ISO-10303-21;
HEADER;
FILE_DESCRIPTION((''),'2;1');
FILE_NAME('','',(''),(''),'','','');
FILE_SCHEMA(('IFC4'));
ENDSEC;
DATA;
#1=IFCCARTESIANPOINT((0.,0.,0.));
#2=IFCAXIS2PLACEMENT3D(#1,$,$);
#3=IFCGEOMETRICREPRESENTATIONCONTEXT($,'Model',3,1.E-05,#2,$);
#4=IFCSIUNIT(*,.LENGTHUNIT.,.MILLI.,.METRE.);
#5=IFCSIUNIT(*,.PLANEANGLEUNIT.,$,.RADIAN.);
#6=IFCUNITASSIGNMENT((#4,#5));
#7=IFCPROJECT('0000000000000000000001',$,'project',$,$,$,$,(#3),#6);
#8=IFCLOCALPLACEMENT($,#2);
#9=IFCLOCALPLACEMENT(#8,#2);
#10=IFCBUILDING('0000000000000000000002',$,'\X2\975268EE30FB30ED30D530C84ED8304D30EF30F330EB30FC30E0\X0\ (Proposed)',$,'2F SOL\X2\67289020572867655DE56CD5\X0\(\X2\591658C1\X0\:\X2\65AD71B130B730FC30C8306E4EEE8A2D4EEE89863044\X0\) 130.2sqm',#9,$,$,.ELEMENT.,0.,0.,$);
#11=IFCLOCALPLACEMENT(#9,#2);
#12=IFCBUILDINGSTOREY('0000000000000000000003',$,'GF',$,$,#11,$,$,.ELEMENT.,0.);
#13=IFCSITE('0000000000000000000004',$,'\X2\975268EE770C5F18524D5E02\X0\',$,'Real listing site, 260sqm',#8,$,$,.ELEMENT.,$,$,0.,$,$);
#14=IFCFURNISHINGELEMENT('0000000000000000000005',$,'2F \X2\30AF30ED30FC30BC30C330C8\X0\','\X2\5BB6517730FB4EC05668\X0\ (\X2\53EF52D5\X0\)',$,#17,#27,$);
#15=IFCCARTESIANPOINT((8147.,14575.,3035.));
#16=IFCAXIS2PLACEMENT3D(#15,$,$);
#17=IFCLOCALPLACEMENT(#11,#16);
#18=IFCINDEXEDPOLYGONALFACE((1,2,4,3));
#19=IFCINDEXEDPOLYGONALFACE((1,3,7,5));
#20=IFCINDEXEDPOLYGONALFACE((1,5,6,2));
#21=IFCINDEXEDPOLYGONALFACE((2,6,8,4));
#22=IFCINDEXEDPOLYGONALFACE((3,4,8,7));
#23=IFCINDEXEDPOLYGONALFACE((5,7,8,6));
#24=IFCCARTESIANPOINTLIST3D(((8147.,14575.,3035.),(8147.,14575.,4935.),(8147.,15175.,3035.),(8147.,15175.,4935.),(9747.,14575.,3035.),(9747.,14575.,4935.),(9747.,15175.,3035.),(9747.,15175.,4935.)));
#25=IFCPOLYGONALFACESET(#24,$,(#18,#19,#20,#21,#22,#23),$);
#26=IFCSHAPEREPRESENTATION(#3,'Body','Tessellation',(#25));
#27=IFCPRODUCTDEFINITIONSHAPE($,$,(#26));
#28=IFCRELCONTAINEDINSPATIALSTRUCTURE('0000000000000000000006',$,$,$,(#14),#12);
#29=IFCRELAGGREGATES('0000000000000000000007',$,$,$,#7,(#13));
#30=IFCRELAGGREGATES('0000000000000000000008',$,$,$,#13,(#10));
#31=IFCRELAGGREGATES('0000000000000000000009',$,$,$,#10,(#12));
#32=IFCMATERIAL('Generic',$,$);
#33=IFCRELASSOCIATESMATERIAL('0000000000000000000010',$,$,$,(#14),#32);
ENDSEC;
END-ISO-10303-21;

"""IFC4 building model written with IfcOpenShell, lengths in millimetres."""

from ifc_helpers import new_model, si_unit, frame, frame_2d, origin, place, context, project, spatial, rectangle, extrude, material, element, save


model = new_model("IFC4")

# Units and contexts
model_context = context("Model", 3, precision=1e-05, world=origin())
ifc_project = project(units=[si_unit("LENGTHUNIT", "METRE", prefix="MILLI"), si_unit("PLANEANGLEUNIT", "RADIAN")], contexts=[model_context])

# Site, building, storey
site_placement = place(None, origin())
site = spatial("IfcSite", under=ifc_project, at=site_placement, Name="青森県弘前市", ObjectType="Real listing site, 260sqm", CompositionType="ELEMENT", RefElevation=0.0)
building_placement = place(site_placement, origin())
building = spatial("IfcBuilding", under=site, at=building_placement, Name="青森・ロフト付きワンルーム (Proposed)", ObjectType="2F SOL木造在来工法(外壁:断熱シートの仮設仮覆い) 130.2sqm", CompositionType="ELEMENT", ElevationOfRefHeight=0.0, ElevationOfTerrain=0.0)
storey_placement = place(building_placement, origin())
storey = spatial("IfcBuildingStorey", under=building, at=storey_placement, Name="GF", CompositionType="ELEMENT", Elevation=0.0)

# Shared definitions
ifc_material_1 = material(Name="Generic")

# Furnishing element
furnishing_1_placement = place(storey_placement, frame((8147.0, 14575.0, 3035.0)))
element("IfcFurnishingElement", 1, at=furnishing_1_placement, inside=storey, material=ifc_material_1, Name="2F クローゼット", Description="家具・什器 (可動)", context=model_context, shape_type="SweptSolid", body=[
    extrude(rectangle(XDim=1600.0, YDim=600.0, at=frame_2d((800.0, 300.0))), frame((8147.0, 14575.0, 3035.0)), (0.0, 0.0, 1.0), 1900.0),
])

save(model, "model.ifc")
